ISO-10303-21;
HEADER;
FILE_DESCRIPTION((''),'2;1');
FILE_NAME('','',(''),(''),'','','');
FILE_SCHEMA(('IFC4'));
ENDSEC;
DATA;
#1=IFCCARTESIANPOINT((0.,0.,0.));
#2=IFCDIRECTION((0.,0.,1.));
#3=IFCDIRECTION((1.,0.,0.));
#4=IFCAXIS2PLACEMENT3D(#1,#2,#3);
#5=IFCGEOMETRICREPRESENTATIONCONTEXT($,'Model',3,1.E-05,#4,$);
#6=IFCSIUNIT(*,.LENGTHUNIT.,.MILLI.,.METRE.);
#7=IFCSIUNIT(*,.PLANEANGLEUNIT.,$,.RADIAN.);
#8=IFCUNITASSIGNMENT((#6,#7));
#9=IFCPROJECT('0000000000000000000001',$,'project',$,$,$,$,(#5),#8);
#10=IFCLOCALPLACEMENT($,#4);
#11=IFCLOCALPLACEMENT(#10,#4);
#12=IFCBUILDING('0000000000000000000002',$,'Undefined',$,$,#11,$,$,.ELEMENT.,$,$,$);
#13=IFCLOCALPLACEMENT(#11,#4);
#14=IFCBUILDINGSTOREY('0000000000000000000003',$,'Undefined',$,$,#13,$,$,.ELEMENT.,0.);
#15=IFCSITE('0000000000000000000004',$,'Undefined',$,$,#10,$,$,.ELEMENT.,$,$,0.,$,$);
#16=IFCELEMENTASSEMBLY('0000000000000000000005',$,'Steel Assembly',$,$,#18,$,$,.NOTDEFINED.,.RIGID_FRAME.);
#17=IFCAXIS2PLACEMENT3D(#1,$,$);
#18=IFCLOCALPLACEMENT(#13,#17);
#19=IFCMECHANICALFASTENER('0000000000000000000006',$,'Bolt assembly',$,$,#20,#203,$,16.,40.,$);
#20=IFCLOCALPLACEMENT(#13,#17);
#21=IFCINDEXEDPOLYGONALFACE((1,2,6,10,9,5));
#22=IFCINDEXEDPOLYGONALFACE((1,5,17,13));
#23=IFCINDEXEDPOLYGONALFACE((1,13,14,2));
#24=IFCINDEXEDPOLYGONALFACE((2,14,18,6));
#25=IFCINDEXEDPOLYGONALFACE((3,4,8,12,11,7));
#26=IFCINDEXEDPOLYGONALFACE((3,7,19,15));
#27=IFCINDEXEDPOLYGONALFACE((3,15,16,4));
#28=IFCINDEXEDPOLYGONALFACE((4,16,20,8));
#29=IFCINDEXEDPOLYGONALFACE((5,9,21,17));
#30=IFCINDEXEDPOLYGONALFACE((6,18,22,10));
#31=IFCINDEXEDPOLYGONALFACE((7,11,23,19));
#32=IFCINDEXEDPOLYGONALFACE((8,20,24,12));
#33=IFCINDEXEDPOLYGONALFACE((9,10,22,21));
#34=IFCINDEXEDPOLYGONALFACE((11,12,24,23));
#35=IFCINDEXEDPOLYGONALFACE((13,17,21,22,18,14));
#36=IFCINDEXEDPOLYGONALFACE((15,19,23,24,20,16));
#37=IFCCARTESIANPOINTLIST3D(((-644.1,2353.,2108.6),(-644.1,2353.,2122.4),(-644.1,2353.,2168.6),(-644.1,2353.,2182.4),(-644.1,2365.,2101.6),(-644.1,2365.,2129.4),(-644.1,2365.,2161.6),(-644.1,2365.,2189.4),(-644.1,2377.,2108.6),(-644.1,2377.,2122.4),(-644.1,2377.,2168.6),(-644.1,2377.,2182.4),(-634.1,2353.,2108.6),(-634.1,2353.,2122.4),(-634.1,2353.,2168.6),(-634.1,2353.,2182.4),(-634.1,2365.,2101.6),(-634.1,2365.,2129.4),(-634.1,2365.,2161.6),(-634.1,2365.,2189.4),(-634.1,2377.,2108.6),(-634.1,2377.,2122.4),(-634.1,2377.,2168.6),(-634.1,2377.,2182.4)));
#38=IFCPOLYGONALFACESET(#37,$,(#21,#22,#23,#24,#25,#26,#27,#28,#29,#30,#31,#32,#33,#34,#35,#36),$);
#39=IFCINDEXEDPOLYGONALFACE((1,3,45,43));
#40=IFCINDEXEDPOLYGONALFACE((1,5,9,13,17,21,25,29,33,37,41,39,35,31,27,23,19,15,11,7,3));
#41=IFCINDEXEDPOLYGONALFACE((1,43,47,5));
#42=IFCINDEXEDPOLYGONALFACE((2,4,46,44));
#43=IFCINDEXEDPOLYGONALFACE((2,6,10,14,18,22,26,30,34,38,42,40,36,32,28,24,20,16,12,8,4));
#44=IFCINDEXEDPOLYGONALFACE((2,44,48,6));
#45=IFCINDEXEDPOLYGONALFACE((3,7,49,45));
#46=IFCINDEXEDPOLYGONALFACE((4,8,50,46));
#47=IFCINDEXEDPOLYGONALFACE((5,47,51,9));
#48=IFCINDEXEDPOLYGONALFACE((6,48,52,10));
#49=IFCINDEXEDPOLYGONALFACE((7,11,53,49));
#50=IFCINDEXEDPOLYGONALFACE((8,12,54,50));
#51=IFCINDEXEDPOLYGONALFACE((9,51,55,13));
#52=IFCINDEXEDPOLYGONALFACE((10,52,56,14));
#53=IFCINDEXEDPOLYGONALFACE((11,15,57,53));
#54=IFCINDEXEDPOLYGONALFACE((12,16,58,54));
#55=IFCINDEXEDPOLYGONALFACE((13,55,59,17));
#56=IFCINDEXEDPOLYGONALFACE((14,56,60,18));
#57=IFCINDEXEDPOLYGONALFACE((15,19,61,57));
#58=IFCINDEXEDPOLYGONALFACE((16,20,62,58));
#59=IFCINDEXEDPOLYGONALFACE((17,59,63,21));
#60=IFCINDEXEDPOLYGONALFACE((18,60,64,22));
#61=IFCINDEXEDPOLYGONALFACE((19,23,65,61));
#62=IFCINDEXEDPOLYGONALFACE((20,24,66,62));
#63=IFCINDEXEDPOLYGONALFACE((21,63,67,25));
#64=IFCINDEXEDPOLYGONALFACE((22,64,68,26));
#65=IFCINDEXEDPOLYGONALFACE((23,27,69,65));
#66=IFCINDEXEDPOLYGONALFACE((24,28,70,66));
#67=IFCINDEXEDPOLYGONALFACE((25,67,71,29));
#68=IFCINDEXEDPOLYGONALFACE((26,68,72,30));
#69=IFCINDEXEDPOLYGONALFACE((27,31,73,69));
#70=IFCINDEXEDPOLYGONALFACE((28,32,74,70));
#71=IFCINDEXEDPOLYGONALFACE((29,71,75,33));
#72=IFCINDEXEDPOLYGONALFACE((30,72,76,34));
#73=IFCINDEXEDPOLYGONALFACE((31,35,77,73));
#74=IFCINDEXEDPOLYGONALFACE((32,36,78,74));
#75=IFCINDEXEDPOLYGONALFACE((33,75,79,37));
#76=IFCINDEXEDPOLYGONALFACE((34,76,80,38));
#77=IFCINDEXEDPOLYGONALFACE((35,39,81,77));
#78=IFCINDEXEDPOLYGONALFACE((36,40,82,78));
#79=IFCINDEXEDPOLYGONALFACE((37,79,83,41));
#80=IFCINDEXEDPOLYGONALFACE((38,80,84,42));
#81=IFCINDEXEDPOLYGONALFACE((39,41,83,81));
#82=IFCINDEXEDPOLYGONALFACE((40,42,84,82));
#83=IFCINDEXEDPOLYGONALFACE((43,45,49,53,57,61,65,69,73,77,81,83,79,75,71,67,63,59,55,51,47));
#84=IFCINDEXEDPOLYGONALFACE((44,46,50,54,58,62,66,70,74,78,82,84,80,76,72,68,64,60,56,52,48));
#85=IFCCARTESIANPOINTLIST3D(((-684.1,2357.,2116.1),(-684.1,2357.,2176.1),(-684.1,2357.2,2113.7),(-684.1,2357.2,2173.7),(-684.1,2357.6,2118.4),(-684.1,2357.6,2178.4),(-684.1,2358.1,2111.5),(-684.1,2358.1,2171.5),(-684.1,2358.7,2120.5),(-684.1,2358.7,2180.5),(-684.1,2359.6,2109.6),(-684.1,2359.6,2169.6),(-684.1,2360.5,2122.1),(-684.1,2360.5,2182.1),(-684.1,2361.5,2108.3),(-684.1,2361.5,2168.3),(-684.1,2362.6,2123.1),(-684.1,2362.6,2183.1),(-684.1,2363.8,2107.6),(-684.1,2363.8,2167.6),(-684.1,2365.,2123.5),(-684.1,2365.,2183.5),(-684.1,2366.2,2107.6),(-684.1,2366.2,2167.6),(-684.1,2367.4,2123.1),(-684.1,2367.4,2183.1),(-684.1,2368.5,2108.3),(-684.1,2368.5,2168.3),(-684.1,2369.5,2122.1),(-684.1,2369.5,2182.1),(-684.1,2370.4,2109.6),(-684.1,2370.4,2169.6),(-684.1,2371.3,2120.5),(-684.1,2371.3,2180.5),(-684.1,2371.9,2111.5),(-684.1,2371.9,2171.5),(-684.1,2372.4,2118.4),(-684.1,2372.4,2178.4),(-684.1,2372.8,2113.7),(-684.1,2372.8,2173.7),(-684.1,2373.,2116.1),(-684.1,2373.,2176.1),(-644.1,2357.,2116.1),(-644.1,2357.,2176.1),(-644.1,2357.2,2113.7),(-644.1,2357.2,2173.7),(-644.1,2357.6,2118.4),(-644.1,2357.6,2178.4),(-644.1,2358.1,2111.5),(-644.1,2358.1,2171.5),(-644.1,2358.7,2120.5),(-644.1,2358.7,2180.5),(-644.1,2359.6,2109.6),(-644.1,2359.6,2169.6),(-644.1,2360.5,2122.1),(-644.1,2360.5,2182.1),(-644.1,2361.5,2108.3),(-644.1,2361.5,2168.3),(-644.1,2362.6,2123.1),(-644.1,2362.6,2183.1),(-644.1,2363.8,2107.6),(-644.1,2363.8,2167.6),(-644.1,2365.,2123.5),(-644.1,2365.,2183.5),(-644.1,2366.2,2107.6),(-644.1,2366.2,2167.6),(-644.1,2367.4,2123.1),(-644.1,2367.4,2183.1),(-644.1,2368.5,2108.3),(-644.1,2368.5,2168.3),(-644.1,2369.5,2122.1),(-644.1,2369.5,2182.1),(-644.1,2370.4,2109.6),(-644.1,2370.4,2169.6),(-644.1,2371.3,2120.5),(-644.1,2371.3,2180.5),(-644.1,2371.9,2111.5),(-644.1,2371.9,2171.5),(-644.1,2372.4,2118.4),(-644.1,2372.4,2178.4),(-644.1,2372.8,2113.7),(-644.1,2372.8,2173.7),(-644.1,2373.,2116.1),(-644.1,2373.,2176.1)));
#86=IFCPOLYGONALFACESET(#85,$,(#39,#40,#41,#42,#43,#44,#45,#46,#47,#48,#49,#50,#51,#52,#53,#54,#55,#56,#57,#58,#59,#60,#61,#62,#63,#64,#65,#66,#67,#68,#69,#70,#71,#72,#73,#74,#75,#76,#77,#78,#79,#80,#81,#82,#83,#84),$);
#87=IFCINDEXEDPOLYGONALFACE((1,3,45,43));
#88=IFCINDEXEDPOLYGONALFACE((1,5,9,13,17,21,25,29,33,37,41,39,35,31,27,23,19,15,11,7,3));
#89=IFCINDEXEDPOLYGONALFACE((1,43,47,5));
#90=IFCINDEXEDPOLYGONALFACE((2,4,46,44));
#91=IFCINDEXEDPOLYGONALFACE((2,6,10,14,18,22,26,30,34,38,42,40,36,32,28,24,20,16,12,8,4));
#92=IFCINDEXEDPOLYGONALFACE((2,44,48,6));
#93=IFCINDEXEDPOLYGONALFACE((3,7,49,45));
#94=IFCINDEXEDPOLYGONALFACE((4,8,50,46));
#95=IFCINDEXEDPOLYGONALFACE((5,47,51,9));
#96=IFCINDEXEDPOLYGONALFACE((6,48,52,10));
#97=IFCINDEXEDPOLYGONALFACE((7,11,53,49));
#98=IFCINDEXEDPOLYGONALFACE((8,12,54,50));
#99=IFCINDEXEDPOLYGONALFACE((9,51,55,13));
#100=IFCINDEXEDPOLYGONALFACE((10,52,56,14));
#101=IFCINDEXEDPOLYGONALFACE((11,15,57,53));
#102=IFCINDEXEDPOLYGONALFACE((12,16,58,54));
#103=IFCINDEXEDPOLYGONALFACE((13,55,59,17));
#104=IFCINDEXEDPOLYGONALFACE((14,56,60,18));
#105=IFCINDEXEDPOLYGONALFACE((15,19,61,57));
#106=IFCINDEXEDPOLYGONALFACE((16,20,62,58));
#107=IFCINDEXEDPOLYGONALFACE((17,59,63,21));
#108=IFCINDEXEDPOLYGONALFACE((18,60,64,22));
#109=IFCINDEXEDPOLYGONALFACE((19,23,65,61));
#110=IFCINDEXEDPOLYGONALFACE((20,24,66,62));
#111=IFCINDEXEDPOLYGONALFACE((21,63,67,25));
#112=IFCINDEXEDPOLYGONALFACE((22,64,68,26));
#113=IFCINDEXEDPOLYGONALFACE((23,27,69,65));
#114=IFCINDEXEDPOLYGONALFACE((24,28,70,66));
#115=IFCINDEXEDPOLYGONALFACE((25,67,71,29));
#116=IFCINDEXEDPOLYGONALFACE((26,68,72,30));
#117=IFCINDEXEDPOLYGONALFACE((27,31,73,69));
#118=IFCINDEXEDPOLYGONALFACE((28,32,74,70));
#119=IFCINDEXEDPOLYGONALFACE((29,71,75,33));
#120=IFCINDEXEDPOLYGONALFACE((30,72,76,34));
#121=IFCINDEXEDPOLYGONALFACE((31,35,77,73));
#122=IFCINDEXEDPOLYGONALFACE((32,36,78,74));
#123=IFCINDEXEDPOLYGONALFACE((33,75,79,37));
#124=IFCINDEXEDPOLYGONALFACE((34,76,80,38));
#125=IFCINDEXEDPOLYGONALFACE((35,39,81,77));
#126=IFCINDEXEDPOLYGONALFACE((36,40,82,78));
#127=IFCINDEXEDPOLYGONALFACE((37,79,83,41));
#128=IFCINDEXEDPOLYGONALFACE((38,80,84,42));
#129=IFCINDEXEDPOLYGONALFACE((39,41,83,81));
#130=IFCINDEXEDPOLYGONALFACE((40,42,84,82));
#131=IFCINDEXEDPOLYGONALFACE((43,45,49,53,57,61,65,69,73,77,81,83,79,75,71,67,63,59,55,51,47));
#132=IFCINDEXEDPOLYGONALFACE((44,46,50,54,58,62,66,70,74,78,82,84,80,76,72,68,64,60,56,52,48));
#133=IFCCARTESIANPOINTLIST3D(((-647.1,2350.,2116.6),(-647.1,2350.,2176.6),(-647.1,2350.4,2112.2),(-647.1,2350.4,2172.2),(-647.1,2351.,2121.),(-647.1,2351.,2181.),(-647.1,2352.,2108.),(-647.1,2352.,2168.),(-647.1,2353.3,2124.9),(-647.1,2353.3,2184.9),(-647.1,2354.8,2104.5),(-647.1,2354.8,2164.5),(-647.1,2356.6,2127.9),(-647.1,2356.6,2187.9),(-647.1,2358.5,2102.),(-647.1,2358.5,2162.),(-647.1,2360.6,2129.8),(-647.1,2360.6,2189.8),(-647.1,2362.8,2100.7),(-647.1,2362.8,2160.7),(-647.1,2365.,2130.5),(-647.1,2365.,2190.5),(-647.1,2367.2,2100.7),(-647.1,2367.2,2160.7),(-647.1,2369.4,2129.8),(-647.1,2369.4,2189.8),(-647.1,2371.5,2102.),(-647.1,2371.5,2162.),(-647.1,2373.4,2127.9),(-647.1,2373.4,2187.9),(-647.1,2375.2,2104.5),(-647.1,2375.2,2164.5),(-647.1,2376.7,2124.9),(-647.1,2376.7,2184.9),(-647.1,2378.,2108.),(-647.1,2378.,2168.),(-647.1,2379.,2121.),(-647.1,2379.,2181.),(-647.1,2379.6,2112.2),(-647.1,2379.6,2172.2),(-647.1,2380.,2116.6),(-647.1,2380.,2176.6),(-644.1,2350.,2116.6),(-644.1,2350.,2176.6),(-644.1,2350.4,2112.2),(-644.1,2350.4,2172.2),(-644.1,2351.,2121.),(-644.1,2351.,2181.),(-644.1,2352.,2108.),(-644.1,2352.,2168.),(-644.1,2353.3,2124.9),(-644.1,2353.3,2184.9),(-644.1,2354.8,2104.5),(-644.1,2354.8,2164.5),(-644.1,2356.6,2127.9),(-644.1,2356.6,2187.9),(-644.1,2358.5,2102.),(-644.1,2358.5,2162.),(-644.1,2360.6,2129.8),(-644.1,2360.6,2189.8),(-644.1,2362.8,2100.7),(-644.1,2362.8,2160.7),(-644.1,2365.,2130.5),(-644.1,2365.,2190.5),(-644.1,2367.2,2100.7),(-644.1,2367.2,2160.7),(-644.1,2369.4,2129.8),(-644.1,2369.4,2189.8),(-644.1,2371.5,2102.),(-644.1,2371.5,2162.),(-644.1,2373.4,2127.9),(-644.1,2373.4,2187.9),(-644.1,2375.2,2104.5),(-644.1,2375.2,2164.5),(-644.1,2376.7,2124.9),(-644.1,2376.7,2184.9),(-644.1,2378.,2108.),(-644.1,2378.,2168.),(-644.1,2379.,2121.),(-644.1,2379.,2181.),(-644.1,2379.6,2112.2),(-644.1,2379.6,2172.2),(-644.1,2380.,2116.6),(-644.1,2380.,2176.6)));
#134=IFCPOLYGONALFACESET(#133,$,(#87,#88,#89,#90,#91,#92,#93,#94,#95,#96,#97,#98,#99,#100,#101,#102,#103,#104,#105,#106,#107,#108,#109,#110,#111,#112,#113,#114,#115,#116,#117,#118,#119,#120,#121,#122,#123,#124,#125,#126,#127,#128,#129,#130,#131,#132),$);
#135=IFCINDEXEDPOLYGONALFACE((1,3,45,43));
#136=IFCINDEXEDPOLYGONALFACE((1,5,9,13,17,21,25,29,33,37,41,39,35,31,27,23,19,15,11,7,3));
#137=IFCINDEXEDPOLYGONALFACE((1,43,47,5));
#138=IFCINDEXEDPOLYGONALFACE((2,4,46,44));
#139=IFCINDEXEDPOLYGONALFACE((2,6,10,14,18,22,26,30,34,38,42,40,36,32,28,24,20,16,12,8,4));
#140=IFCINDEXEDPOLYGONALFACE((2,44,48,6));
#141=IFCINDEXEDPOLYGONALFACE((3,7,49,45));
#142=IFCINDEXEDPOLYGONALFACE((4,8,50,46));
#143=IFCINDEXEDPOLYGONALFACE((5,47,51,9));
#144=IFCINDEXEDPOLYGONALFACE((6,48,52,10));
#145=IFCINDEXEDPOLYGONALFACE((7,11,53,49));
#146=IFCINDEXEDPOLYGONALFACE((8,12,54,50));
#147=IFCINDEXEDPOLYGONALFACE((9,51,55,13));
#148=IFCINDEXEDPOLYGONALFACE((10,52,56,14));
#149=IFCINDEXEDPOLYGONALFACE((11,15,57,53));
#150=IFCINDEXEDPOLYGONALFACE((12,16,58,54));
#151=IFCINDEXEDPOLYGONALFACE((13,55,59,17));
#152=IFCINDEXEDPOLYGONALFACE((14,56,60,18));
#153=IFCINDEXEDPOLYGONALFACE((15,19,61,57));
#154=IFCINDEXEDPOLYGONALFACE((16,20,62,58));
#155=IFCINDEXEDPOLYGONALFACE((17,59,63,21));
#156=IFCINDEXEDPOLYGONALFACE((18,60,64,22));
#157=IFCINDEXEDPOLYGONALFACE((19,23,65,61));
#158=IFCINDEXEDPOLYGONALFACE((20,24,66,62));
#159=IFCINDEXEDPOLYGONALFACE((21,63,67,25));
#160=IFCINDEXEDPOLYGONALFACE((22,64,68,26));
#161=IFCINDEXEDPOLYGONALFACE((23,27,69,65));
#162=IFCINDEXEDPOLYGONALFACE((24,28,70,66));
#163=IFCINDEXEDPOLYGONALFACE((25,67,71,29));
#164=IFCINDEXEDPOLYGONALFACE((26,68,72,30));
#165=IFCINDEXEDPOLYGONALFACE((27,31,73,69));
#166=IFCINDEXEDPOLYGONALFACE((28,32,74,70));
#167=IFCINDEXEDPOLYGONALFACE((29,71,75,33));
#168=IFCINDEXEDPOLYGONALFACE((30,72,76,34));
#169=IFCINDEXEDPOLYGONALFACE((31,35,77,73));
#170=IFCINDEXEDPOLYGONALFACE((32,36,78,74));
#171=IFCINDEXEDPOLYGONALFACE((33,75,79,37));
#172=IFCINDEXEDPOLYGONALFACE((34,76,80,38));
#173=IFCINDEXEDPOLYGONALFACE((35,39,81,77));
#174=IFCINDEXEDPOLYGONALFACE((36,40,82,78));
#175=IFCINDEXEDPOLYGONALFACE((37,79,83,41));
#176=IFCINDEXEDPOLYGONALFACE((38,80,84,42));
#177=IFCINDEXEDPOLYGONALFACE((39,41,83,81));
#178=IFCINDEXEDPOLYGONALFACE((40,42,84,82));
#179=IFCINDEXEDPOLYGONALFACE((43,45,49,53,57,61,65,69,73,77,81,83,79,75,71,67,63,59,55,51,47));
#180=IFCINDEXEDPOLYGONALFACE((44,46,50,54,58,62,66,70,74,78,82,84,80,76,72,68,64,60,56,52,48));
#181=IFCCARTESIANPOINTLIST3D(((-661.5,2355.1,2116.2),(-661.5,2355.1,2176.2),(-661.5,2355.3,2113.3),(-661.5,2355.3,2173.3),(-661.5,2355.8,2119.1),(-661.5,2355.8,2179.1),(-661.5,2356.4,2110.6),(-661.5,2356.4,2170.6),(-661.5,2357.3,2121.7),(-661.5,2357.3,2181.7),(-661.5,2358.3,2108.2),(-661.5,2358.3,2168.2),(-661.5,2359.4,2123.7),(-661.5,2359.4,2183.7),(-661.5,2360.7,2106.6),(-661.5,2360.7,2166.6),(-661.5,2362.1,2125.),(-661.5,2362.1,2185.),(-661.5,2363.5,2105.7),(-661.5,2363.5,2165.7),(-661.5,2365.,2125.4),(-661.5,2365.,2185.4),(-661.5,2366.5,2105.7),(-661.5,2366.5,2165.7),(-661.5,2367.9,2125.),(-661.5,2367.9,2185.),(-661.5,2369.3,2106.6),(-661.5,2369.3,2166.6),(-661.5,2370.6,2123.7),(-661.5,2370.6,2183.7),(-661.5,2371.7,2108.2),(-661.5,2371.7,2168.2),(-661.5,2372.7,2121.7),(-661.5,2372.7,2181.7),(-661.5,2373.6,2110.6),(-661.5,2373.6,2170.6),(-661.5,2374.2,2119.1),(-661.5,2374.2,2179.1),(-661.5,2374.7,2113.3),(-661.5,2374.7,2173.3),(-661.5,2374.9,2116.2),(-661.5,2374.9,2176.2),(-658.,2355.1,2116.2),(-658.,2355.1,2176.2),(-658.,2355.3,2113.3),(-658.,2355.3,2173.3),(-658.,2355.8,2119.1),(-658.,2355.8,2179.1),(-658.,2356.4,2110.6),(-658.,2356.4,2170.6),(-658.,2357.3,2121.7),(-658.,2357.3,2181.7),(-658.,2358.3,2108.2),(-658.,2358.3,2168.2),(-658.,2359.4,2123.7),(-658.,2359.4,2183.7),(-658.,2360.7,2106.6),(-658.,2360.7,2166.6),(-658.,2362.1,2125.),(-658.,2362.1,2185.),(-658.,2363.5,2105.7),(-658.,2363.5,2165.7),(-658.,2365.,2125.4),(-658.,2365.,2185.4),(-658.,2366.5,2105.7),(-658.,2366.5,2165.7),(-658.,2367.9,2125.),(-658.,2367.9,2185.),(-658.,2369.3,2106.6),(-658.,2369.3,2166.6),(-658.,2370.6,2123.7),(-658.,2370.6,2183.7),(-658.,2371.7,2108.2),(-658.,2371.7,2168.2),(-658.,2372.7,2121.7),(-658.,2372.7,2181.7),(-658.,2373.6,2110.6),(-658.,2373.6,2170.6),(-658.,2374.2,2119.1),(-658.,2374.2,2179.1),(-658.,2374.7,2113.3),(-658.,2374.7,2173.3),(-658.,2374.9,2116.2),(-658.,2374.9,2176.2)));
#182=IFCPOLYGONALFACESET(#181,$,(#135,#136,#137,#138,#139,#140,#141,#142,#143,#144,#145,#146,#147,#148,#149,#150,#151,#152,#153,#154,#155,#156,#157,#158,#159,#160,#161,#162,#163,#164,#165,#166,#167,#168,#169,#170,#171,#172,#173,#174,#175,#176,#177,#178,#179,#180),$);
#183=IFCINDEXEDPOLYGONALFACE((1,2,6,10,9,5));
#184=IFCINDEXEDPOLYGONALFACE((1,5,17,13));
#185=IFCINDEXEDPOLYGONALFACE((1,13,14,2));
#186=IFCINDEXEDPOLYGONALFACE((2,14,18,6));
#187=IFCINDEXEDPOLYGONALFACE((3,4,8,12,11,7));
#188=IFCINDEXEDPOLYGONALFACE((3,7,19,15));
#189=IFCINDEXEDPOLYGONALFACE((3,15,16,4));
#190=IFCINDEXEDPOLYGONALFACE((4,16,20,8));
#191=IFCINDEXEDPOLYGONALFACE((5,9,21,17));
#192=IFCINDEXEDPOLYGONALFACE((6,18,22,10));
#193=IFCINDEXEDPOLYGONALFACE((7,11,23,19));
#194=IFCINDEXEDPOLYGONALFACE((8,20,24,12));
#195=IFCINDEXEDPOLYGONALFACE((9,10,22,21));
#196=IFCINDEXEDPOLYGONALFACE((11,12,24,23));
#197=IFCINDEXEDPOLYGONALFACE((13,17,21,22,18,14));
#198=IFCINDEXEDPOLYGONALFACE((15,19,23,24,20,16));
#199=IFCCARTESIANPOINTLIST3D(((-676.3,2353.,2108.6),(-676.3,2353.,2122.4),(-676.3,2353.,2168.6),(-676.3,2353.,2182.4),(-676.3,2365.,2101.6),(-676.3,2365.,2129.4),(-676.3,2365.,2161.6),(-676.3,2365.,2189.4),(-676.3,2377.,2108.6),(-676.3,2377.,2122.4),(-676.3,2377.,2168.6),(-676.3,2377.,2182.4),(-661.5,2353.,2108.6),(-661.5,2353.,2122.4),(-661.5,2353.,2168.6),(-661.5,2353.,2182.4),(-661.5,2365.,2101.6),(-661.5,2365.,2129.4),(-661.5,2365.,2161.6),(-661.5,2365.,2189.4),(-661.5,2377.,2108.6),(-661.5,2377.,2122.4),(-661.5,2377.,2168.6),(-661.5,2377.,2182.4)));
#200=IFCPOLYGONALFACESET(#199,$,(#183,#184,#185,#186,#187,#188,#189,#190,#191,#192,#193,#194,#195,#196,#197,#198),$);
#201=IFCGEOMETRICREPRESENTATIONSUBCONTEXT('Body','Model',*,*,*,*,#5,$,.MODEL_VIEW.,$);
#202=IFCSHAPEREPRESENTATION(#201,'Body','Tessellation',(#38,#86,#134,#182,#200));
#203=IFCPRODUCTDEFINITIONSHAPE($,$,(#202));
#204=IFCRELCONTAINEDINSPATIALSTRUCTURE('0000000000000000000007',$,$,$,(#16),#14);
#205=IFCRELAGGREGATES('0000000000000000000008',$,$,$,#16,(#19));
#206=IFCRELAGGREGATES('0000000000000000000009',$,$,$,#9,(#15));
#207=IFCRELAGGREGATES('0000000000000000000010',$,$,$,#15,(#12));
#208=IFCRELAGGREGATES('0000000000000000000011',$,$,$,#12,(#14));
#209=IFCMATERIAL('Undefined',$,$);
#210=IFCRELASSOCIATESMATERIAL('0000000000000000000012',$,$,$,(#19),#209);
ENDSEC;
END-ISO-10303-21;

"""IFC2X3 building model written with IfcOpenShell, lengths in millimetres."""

from ifc_helpers import new_model, si_unit, frame, origin_with_axes, origin_2d_with_axis, place, context, subcontext, project, spatial, polyline, circle, outline, extrude, source, transform, mapped, material, element, aggregate, save


model = new_model("IFC2X3")

# Units and contexts
model_context = context("Model", 3, precision=1e-05, world=origin_with_axes())
body_context = subcontext(model_context, "Body", "Model", "MODEL_VIEW")
ifc_project = project(units=[si_unit("LENGTHUNIT", "METRE", prefix="MILLI"), si_unit("PLANEANGLEUNIT", "RADIAN")], contexts=[model_context])

# Site, building, storey
site_placement = place(None, origin_with_axes())
site = spatial("IfcSite", under=ifc_project, at=site_placement, Name="Undefined", CompositionType="ELEMENT", RefElevation=0.0)
building_placement = place(site_placement, origin_with_axes())
building = spatial("IfcBuilding", under=site, at=building_placement, Name="Undefined", CompositionType="ELEMENT")
storey_placement = place(building_placement, origin_with_axes())
storey = spatial("IfcBuildingStorey", under=building, at=storey_placement, Name="Undefined", CompositionType="ELEMENT", Elevation=0.0)

# Element assembly, mechanical fastener
ifc_material_1 = material(Name="Undefined")
shared_shape_1 = source(origin_with_axes(), body_context, "Body", "SweptSolid", [
    extrude(outline(polyline([(13.9, 0.0), (6.9, 12.0), (-6.9, 12.0), (-13.9, 0.0), (-6.9, -12.0), (6.9, -12.0), (13.9, 0.0)])), frame((0.0, -17.9, 0.0), z_axis=(0.0, 1.0, 0.0), x_axis=(1.0, 0.0, 0.0)), (0.0, 0.0, 1.0), 10.0),
    extrude(circle(Radius=8.0, at=origin_2d_with_axis()), frame((0.0, -7.9, 0.0), z_axis=(0.0, 1.0, 0.0), x_axis=(1.0, 0.0, 0.0)), (0.0, 0.0, 1.0), 40.0),
    extrude(circle(Radius=15.0, at=origin_2d_with_axis()), frame((0.0, -7.9, 0.0), z_axis=(0.0, 1.0, 0.0), x_axis=(1.0, 0.0, 0.0)), (0.0, 0.0, 1.0), 3.0),
    extrude(circle(Radius=9.9, at=origin_2d_with_axis()), frame((0.0, 6.0, 0.0), z_axis=(0.0, 1.0, 0.0), x_axis=(1.0, 0.0, 0.0)), (0.0, 0.0, 1.0), 3.5),
    extrude(outline(polyline([(13.9, 0.0), (6.9, 12.0), (-6.9, 12.0), (-13.9, 0.0), (-6.9, -12.0), (6.9, -12.0), (13.9, 0.0)])), frame((0.0, 9.5, 0.0), z_axis=(0.0, 1.0, 0.0), x_axis=(1.0, 0.0, 0.0)), (0.0, 0.0, 1.0), 14.8),
])
assembly_1_placement = place(storey_placement, origin_with_axes())
assembly_1 = element("IfcElementAssembly", 1, at=assembly_1_placement, inside=storey, Name="Steel Assembly", AssemblyPlace="NOTDEFINED", PredefinedType="RIGID_FRAME")
mechanical_fastener_1_placement = place(assembly_1_placement, frame((-652.0, 2365.0, 2115.5), z_axis=(0.0, -1.0, 0.0), x_axis=(0.0, 0.0, 1.0)))
mechanical_fastener_1 = element("IfcMechanicalFastener", 2, at=mechanical_fastener_1_placement, material=ifc_material_1, Name="Bolt assembly", NominalDiameter=16.0, NominalLength=40.0, context=body_context, shape_type="MappedRepresentation", body=[
    mapped(shared_shape_1, transform((0.0, 0.0, 0.0))),
    mapped(shared_shape_1, transform((60.0, 0.0, 0.0))),
])
aggregate(assembly_1, [mechanical_fastener_1])

save(model, "model.ifc")
